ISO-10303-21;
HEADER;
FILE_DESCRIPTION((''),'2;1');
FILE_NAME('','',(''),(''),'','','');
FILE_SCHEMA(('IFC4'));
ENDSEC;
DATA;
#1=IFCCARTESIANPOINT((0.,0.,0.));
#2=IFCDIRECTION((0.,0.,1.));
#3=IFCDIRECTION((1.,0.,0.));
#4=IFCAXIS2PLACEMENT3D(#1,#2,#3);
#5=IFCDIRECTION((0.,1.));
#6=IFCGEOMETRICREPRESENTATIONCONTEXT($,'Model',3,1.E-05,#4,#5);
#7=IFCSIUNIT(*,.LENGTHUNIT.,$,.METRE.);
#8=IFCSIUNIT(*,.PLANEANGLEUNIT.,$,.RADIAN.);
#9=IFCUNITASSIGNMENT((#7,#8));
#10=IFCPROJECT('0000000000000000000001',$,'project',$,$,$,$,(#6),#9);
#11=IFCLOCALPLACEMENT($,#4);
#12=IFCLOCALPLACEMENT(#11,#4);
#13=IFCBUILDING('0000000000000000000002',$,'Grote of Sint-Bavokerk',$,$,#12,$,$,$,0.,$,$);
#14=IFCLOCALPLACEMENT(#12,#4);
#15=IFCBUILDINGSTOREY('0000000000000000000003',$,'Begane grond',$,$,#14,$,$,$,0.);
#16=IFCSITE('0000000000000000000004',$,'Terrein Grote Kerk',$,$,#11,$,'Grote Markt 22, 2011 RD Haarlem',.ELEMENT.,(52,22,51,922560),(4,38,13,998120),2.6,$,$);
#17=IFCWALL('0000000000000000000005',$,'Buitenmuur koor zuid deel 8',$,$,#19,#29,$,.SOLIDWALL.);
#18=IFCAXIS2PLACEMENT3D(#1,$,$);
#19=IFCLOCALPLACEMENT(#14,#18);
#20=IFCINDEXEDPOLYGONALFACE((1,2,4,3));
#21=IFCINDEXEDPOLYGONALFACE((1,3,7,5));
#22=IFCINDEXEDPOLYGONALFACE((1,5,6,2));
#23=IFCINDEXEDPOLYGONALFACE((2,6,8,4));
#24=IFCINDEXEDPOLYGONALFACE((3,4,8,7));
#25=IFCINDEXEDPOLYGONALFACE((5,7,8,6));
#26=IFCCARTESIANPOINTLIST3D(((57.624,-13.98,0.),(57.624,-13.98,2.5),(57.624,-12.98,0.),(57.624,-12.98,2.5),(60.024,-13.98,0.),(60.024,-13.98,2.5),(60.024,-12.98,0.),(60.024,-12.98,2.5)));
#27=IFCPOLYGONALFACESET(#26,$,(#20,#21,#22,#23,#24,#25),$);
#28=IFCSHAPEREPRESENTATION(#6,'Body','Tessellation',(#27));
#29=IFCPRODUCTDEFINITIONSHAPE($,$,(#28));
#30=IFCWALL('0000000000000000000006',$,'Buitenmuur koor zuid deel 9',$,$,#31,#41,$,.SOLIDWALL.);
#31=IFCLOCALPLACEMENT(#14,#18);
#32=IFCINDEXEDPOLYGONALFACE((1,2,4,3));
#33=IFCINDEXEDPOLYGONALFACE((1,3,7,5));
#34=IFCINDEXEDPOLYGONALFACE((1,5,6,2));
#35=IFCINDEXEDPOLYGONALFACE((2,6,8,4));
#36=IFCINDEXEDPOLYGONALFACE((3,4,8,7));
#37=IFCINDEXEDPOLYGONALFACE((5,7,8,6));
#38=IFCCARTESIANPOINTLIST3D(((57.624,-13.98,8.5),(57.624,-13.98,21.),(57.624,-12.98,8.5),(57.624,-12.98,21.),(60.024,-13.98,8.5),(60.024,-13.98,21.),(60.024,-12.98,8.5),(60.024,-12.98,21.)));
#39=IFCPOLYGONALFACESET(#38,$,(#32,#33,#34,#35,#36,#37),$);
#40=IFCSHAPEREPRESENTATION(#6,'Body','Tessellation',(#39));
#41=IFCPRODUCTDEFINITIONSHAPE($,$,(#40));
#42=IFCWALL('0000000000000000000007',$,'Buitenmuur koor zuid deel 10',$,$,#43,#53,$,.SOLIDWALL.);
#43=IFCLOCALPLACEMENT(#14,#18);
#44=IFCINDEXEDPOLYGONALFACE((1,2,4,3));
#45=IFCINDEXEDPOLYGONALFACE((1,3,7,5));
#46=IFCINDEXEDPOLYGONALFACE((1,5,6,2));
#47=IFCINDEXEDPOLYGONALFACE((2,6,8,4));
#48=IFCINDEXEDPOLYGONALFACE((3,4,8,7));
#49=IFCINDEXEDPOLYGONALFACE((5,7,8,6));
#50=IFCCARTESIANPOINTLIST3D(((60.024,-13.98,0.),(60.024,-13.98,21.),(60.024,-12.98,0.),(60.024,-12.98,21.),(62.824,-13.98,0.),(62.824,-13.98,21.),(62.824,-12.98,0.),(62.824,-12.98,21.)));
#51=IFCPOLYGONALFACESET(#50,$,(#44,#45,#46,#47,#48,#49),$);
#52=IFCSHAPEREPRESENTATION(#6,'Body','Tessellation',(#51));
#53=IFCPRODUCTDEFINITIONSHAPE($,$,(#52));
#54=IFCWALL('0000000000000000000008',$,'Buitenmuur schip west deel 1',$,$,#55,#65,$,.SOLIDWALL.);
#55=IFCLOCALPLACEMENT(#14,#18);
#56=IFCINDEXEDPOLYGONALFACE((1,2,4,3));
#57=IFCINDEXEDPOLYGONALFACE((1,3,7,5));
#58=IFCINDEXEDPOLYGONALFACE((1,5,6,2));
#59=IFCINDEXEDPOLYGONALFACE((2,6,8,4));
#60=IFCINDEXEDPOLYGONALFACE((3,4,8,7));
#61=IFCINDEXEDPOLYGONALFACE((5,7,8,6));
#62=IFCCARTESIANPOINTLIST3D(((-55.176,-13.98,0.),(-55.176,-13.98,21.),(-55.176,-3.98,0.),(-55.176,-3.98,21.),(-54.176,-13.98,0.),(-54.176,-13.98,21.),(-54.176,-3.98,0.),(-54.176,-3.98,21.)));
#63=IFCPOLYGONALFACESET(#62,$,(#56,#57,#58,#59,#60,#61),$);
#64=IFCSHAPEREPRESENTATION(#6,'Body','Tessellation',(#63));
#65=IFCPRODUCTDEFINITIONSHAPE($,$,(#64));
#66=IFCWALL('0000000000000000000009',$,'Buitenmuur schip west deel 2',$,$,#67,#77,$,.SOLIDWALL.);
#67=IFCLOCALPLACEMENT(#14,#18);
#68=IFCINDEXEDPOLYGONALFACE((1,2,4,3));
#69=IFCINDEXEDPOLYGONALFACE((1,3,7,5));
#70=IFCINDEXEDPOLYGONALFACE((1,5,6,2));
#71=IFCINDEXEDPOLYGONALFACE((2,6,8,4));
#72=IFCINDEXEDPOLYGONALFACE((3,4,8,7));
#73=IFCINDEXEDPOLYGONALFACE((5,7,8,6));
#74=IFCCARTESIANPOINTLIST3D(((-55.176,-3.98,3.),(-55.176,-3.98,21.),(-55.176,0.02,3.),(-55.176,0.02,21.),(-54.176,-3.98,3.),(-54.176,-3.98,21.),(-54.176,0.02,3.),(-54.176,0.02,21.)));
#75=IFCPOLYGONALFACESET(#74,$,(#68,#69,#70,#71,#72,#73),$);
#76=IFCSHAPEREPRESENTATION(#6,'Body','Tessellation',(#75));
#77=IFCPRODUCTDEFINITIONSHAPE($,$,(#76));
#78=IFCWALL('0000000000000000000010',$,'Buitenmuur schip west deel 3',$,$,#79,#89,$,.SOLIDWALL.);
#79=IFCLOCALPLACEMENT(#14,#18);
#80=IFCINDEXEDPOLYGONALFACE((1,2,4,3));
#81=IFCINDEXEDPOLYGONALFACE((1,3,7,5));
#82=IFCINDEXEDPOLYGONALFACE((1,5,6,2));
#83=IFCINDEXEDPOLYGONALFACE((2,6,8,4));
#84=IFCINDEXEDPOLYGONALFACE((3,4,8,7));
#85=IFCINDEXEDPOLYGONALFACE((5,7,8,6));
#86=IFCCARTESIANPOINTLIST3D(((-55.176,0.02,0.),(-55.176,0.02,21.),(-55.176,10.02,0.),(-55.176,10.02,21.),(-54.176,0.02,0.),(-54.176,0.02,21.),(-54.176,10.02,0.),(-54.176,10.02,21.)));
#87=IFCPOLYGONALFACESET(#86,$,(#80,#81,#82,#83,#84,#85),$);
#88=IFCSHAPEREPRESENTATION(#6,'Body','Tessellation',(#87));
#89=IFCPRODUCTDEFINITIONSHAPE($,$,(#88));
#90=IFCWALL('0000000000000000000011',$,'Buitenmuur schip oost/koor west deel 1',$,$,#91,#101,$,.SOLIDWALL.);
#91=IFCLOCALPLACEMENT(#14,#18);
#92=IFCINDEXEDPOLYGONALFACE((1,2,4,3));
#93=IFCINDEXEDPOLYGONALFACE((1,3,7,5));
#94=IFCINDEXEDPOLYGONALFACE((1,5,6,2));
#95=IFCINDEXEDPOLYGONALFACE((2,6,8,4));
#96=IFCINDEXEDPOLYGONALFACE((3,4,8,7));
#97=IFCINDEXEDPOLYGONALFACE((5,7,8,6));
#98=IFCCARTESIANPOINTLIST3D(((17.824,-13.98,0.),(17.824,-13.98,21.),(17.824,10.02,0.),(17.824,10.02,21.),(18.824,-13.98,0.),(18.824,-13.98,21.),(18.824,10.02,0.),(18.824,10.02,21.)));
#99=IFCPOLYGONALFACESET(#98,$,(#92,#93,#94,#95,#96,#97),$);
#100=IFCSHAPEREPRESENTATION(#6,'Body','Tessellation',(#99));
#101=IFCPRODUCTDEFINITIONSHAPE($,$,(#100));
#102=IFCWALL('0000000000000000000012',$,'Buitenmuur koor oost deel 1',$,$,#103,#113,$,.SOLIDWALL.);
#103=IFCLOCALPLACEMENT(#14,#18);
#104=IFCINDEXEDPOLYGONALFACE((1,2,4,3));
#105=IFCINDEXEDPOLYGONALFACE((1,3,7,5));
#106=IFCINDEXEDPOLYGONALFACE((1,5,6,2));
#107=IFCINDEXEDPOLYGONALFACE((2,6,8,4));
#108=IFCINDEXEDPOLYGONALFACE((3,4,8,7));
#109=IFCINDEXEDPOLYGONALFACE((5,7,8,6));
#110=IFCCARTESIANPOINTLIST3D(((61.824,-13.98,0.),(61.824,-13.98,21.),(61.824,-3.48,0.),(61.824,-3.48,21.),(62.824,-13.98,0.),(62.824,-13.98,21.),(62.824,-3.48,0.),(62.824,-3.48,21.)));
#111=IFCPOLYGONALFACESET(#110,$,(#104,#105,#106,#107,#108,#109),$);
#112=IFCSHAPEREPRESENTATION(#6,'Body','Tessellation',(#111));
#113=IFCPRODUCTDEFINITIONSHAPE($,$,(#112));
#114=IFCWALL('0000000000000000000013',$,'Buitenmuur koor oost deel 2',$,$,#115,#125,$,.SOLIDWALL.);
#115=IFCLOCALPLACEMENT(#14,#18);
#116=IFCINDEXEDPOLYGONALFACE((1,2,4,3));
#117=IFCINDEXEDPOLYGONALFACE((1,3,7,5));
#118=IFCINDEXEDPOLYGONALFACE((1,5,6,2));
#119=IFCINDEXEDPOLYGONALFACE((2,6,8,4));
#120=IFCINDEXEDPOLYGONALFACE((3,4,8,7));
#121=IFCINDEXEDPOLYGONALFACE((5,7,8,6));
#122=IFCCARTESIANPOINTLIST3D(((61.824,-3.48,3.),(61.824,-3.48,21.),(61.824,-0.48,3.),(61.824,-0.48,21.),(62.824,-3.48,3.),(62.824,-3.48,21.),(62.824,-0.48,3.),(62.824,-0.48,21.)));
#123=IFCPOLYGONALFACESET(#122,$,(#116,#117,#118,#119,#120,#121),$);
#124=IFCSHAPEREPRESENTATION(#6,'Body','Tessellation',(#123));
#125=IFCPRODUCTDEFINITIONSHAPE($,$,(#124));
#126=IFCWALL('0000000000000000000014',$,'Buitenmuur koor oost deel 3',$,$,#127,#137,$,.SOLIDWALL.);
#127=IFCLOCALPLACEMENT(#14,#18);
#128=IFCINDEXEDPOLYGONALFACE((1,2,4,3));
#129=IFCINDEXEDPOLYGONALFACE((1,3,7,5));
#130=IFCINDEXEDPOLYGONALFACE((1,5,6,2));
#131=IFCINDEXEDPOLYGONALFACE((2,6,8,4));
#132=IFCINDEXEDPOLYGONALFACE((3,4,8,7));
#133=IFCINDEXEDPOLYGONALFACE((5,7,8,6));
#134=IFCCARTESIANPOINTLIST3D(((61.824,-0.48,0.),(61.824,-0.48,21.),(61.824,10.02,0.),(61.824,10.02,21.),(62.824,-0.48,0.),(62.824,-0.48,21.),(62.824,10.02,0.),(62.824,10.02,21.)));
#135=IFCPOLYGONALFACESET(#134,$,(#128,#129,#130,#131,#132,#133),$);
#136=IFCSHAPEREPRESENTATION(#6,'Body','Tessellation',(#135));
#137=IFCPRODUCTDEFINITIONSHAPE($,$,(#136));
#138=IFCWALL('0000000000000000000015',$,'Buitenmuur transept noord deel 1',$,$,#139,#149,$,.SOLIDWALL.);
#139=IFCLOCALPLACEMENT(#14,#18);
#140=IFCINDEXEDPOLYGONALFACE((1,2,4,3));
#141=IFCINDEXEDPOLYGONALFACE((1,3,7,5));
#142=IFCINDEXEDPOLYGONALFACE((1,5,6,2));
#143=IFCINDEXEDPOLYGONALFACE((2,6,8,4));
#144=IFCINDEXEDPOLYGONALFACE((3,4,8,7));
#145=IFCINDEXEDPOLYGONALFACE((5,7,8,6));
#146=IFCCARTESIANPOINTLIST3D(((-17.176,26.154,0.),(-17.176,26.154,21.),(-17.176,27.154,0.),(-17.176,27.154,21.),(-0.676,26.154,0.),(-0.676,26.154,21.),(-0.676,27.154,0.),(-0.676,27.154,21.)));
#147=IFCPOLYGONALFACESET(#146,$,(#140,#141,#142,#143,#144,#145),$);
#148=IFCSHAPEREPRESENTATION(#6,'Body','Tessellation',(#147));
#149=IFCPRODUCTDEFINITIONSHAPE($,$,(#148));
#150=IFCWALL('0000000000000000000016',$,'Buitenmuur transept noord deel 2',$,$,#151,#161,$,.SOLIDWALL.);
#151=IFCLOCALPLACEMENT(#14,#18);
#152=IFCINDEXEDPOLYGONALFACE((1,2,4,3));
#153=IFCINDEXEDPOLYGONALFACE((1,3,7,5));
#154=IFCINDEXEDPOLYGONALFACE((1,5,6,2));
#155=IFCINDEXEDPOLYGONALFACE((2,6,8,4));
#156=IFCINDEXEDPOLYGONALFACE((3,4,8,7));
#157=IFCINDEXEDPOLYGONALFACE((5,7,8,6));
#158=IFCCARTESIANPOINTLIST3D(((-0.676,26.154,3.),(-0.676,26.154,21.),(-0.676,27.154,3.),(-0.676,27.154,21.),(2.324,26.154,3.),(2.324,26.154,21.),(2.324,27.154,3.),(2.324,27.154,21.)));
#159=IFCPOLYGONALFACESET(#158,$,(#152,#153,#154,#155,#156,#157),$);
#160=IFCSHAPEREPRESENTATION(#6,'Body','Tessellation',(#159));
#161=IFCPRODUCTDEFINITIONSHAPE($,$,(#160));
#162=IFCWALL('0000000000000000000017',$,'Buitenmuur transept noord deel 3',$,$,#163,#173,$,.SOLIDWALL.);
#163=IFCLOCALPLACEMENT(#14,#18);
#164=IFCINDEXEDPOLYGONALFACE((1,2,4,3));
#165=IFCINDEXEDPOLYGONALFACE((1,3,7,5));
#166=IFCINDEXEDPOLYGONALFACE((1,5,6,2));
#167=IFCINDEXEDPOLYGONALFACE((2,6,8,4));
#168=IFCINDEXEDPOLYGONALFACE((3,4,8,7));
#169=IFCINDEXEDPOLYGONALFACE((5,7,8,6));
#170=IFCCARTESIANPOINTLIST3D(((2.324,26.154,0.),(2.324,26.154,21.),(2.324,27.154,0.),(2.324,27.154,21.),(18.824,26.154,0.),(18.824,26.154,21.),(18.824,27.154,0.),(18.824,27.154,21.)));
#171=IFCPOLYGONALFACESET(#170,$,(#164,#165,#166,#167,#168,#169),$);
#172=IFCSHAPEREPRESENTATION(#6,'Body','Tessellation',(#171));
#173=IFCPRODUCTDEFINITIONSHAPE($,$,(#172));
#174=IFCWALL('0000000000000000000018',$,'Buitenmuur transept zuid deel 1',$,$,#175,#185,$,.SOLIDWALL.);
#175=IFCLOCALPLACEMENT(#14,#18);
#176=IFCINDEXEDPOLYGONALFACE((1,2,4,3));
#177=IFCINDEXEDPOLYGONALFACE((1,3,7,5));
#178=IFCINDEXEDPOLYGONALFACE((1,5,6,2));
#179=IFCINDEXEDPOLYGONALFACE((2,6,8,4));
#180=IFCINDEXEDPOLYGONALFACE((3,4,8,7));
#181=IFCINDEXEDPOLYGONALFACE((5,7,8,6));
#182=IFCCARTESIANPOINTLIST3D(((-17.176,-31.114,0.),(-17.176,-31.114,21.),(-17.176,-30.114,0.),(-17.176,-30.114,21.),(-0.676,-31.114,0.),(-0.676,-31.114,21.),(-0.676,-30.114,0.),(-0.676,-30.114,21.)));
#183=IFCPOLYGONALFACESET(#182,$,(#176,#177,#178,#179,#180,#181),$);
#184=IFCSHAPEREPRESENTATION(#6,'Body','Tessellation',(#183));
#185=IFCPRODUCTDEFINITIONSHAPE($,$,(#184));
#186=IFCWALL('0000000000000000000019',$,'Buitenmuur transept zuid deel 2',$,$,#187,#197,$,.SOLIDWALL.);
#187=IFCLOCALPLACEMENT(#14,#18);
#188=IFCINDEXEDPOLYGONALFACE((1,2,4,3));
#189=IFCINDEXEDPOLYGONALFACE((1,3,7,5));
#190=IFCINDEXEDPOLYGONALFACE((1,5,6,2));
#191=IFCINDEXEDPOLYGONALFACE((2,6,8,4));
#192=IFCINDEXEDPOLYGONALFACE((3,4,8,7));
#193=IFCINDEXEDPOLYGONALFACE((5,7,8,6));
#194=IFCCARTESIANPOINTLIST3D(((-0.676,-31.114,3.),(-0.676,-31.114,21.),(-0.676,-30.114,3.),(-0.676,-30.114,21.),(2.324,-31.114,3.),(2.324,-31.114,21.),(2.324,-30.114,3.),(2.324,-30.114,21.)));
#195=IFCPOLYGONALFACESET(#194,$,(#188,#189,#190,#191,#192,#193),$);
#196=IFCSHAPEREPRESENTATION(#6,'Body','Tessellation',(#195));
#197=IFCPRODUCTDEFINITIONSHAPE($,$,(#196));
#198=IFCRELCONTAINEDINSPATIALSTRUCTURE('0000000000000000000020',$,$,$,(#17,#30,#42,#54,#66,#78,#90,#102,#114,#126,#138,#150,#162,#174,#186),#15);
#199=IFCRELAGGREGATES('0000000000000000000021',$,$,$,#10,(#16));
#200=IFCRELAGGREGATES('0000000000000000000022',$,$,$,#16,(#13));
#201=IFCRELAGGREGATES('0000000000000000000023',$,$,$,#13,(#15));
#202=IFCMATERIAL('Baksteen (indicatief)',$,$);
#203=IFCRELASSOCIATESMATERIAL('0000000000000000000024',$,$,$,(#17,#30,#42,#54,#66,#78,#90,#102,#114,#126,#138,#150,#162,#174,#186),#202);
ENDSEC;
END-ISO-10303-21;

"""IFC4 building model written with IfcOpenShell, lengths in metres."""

from ifc_helpers import new_model, si_unit, direction, frame, origin_with_axes, place, context, project, spatial, indexed_curve, outline, extrude, material, element, save


model = new_model("IFC4")

# Units and contexts
model_context = context("Model", 3, precision=1e-05, world=origin_with_axes(), true_north=direction((0.0, 1.0)))
ifc_project = project(units=[si_unit("LENGTHUNIT", "METRE"), si_unit("PLANEANGLEUNIT", "RADIAN")], contexts=[model_context])

# Site, building, storey
site_placement = place(None, origin_with_axes())
site = spatial("IfcSite", under=ifc_project, at=site_placement, Name="Terrein Grote Kerk", LongName="Grote Markt 22, 2011 RD Haarlem", CompositionType="ELEMENT", RefLatitude=(52, 22, 51, 922560), RefLongitude=(4, 38, 13, 998120), RefElevation=2.6)
building_placement = place(site_placement, origin_with_axes())
building = spatial("IfcBuilding", under=site, at=building_placement, Name="Grote of Sint-Bavokerk", ElevationOfRefHeight=0.0)
storey_placement = place(building_placement, origin_with_axes())
storey = spatial("IfcBuildingStorey", under=building, at=storey_placement, Name="Begane grond", Elevation=0.0)

# Walls
ifc_material = material(Name="Baksteen (indicatief)")
wall_1_placement = place(storey_placement, origin_with_axes())
element("IfcWall", 1, at=wall_1_placement, inside=storey, material=ifc_material, Name="Buitenmuur koor zuid deel 8", PredefinedType="SOLIDWALL", context=model_context, shape_type="SweptSolid", body=[
    extrude(outline(indexed_curve([(57.624, -13.98), (60.024, -13.98), (60.024, -12.98), (57.624, -12.98), (57.624, -13.98)])), origin_with_axes(), (0.0, 0.0, 1.0), 2.5),
])
wall_2_placement = place(storey_placement, origin_with_axes())
element("IfcWall", 2, at=wall_2_placement, inside=storey, material=ifc_material, Name="Buitenmuur koor zuid deel 9", PredefinedType="SOLIDWALL", context=model_context, shape_type="SweptSolid", body=[
    extrude(outline(indexed_curve([(57.624, -13.98), (60.024, -13.98), (60.024, -12.98), (57.624, -12.98), (57.624, -13.98)])), frame((0.0, 0.0, 8.5), z_axis=(0.0, 0.0, 1.0), x_axis=(1.0, 0.0, 0.0)), (0.0, 0.0, 1.0), 12.5),
])
wall_3_placement = place(storey_placement, origin_with_axes())
element("IfcWall", 3, at=wall_3_placement, inside=storey, material=ifc_material, Name="Buitenmuur koor zuid deel 10", PredefinedType="SOLIDWALL", context=model_context, shape_type="SweptSolid", body=[
    extrude(outline(indexed_curve([(60.024, -13.98), (62.824, -13.98), (62.824, -12.98), (60.024, -12.98), (60.024, -13.98)])), origin_with_axes(), (0.0, 0.0, 1.0), 21.0),
])
wall_4_placement = place(storey_placement, origin_with_axes())
element("IfcWall", 4, at=wall_4_placement, inside=storey, material=ifc_material, Name="Buitenmuur schip west deel 1", PredefinedType="SOLIDWALL", context=model_context, shape_type="SweptSolid", body=[
    extrude(outline(indexed_curve([(-55.176, -13.98), (-54.176, -13.98), (-54.176, -3.98), (-55.176, -3.98), (-55.176, -13.98)])), origin_with_axes(), (0.0, 0.0, 1.0), 21.0),
])
wall_5_placement = place(storey_placement, origin_with_axes())
element("IfcWall", 5, at=wall_5_placement, inside=storey, material=ifc_material, Name="Buitenmuur schip west deel 2", PredefinedType="SOLIDWALL", context=model_context, shape_type="SweptSolid", body=[
    extrude(outline(indexed_curve([(-55.176, -3.98), (-54.176, -3.98), (-54.176, 0.02), (-55.176, 0.02), (-55.176, -3.98)])), frame((0.0, 0.0, 3.0), z_axis=(0.0, 0.0, 1.0), x_axis=(1.0, 0.0, 0.0)), (0.0, 0.0, 1.0), 18.0),
])
wall_6_placement = place(storey_placement, origin_with_axes())
element("IfcWall", 6, at=wall_6_placement, inside=storey, material=ifc_material, Name="Buitenmuur schip west deel 3", PredefinedType="SOLIDWALL", context=model_context, shape_type="SweptSolid", body=[
    extrude(outline(indexed_curve([(-55.176, 0.02), (-54.176, 0.02), (-54.176, 10.02), (-55.176, 10.02), (-55.176, 0.02)])), origin_with_axes(), (0.0, 0.0, 1.0), 21.0),
])
wall_7_placement = place(storey_placement, origin_with_axes())
element("IfcWall", 7, at=wall_7_placement, inside=storey, material=ifc_material, Name="Buitenmuur schip oost/koor west deel 1", PredefinedType="SOLIDWALL", context=model_context, shape_type="SweptSolid", body=[
    extrude(outline(indexed_curve([(17.824, -13.98), (18.824, -13.98), (18.824, 10.02), (17.824, 10.02), (17.824, -13.98)])), origin_with_axes(), (0.0, 0.0, 1.0), 21.0),
])
wall_8_placement = place(storey_placement, origin_with_axes())
element("IfcWall", 8, at=wall_8_placement, inside=storey, material=ifc_material, Name="Buitenmuur koor oost deel 1", PredefinedType="SOLIDWALL", context=model_context, shape_type="SweptSolid", body=[
    extrude(outline(indexed_curve([(61.824, -13.98), (62.824, -13.98), (62.824, -3.48), (61.824, -3.48), (61.824, -13.98)])), origin_with_axes(), (0.0, 0.0, 1.0), 21.0),
])
wall_9_placement = place(storey_placement, origin_with_axes())
element("IfcWall", 9, at=wall_9_placement, inside=storey, material=ifc_material, Name="Buitenmuur koor oost deel 2", PredefinedType="SOLIDWALL", context=model_context, shape_type="SweptSolid", body=[
    extrude(outline(indexed_curve([(61.824, -3.48), (62.824, -3.48), (62.824, -0.48), (61.824, -0.48), (61.824, -3.48)])), frame((0.0, 0.0, 3.0), z_axis=(0.0, 0.0, 1.0), x_axis=(1.0, 0.0, 0.0)), (0.0, 0.0, 1.0), 18.0),
])
wall_10_placement = place(storey_placement, origin_with_axes())
element("IfcWall", 10, at=wall_10_placement, inside=storey, material=ifc_material, Name="Buitenmuur koor oost deel 3", PredefinedType="SOLIDWALL", context=model_context, shape_type="SweptSolid", body=[
    extrude(outline(indexed_curve([(61.824, -0.48), (62.824, -0.48), (62.824, 10.02), (61.824, 10.02), (61.824, -0.48)])), origin_with_axes(), (0.0, 0.0, 1.0), 21.0),
])
wall_11_placement = place(storey_placement, origin_with_axes())
element("IfcWall", 11, at=wall_11_placement, inside=storey, material=ifc_material, Name="Buitenmuur transept noord deel 1", PredefinedType="SOLIDWALL", context=model_context, shape_type="SweptSolid", body=[
    extrude(outline(indexed_curve([(-17.176, 26.154), (-0.676, 26.154), (-0.676, 27.154), (-17.176, 27.154), (-17.176, 26.154)])), origin_with_axes(), (0.0, 0.0, 1.0), 21.0),
])
wall_12_placement = place(storey_placement, origin_with_axes())
element("IfcWall", 12, at=wall_12_placement, inside=storey, material=ifc_material, Name="Buitenmuur transept noord deel 2", PredefinedType="SOLIDWALL", context=model_context, shape_type="SweptSolid", body=[
    extrude(outline(indexed_curve([(-0.676, 26.154), (2.324, 26.154), (2.324, 27.154), (-0.676, 27.154), (-0.676, 26.154)])), frame((0.0, 0.0, 3.0), z_axis=(0.0, 0.0, 1.0), x_axis=(1.0, 0.0, 0.0)), (0.0, 0.0, 1.0), 18.0),
])
wall_13_placement = place(storey_placement, origin_with_axes())
element("IfcWall", 13, at=wall_13_placement, inside=storey, material=ifc_material, Name="Buitenmuur transept noord deel 3", PredefinedType="SOLIDWALL", context=model_context, shape_type="SweptSolid", body=[
    extrude(outline(indexed_curve([(2.324, 26.154), (18.824, 26.154), (18.824, 27.154), (2.324, 27.154), (2.324, 26.154)])), origin_with_axes(), (0.0, 0.0, 1.0), 21.0),
])
wall_14_placement = place(storey_placement, origin_with_axes())
element("IfcWall", 14, at=wall_14_placement, inside=storey, material=ifc_material, Name="Buitenmuur transept zuid deel 1", PredefinedType="SOLIDWALL", context=model_context, shape_type="SweptSolid", body=[
    extrude(outline(indexed_curve([(-17.176, -31.114), (-0.676, -31.114), (-0.676, -30.114), (-17.176, -30.114), (-17.176, -31.114)])), origin_with_axes(), (0.0, 0.0, 1.0), 21.0),
])
wall_15_placement = place(storey_placement, origin_with_axes())
element("IfcWall", 15, at=wall_15_placement, inside=storey, material=ifc_material, Name="Buitenmuur transept zuid deel 2", PredefinedType="SOLIDWALL", context=model_context, shape_type="SweptSolid", body=[
    extrude(outline(indexed_curve([(-0.676, -31.114), (2.324, -31.114), (2.324, -30.114), (-0.676, -30.114), (-0.676, -31.114)])), frame((0.0, 0.0, 3.0), z_axis=(0.0, 0.0, 1.0), x_axis=(1.0, 0.0, 0.0)), (0.0, 0.0, 1.0), 18.0),
])

save(model, "model.ifc")
